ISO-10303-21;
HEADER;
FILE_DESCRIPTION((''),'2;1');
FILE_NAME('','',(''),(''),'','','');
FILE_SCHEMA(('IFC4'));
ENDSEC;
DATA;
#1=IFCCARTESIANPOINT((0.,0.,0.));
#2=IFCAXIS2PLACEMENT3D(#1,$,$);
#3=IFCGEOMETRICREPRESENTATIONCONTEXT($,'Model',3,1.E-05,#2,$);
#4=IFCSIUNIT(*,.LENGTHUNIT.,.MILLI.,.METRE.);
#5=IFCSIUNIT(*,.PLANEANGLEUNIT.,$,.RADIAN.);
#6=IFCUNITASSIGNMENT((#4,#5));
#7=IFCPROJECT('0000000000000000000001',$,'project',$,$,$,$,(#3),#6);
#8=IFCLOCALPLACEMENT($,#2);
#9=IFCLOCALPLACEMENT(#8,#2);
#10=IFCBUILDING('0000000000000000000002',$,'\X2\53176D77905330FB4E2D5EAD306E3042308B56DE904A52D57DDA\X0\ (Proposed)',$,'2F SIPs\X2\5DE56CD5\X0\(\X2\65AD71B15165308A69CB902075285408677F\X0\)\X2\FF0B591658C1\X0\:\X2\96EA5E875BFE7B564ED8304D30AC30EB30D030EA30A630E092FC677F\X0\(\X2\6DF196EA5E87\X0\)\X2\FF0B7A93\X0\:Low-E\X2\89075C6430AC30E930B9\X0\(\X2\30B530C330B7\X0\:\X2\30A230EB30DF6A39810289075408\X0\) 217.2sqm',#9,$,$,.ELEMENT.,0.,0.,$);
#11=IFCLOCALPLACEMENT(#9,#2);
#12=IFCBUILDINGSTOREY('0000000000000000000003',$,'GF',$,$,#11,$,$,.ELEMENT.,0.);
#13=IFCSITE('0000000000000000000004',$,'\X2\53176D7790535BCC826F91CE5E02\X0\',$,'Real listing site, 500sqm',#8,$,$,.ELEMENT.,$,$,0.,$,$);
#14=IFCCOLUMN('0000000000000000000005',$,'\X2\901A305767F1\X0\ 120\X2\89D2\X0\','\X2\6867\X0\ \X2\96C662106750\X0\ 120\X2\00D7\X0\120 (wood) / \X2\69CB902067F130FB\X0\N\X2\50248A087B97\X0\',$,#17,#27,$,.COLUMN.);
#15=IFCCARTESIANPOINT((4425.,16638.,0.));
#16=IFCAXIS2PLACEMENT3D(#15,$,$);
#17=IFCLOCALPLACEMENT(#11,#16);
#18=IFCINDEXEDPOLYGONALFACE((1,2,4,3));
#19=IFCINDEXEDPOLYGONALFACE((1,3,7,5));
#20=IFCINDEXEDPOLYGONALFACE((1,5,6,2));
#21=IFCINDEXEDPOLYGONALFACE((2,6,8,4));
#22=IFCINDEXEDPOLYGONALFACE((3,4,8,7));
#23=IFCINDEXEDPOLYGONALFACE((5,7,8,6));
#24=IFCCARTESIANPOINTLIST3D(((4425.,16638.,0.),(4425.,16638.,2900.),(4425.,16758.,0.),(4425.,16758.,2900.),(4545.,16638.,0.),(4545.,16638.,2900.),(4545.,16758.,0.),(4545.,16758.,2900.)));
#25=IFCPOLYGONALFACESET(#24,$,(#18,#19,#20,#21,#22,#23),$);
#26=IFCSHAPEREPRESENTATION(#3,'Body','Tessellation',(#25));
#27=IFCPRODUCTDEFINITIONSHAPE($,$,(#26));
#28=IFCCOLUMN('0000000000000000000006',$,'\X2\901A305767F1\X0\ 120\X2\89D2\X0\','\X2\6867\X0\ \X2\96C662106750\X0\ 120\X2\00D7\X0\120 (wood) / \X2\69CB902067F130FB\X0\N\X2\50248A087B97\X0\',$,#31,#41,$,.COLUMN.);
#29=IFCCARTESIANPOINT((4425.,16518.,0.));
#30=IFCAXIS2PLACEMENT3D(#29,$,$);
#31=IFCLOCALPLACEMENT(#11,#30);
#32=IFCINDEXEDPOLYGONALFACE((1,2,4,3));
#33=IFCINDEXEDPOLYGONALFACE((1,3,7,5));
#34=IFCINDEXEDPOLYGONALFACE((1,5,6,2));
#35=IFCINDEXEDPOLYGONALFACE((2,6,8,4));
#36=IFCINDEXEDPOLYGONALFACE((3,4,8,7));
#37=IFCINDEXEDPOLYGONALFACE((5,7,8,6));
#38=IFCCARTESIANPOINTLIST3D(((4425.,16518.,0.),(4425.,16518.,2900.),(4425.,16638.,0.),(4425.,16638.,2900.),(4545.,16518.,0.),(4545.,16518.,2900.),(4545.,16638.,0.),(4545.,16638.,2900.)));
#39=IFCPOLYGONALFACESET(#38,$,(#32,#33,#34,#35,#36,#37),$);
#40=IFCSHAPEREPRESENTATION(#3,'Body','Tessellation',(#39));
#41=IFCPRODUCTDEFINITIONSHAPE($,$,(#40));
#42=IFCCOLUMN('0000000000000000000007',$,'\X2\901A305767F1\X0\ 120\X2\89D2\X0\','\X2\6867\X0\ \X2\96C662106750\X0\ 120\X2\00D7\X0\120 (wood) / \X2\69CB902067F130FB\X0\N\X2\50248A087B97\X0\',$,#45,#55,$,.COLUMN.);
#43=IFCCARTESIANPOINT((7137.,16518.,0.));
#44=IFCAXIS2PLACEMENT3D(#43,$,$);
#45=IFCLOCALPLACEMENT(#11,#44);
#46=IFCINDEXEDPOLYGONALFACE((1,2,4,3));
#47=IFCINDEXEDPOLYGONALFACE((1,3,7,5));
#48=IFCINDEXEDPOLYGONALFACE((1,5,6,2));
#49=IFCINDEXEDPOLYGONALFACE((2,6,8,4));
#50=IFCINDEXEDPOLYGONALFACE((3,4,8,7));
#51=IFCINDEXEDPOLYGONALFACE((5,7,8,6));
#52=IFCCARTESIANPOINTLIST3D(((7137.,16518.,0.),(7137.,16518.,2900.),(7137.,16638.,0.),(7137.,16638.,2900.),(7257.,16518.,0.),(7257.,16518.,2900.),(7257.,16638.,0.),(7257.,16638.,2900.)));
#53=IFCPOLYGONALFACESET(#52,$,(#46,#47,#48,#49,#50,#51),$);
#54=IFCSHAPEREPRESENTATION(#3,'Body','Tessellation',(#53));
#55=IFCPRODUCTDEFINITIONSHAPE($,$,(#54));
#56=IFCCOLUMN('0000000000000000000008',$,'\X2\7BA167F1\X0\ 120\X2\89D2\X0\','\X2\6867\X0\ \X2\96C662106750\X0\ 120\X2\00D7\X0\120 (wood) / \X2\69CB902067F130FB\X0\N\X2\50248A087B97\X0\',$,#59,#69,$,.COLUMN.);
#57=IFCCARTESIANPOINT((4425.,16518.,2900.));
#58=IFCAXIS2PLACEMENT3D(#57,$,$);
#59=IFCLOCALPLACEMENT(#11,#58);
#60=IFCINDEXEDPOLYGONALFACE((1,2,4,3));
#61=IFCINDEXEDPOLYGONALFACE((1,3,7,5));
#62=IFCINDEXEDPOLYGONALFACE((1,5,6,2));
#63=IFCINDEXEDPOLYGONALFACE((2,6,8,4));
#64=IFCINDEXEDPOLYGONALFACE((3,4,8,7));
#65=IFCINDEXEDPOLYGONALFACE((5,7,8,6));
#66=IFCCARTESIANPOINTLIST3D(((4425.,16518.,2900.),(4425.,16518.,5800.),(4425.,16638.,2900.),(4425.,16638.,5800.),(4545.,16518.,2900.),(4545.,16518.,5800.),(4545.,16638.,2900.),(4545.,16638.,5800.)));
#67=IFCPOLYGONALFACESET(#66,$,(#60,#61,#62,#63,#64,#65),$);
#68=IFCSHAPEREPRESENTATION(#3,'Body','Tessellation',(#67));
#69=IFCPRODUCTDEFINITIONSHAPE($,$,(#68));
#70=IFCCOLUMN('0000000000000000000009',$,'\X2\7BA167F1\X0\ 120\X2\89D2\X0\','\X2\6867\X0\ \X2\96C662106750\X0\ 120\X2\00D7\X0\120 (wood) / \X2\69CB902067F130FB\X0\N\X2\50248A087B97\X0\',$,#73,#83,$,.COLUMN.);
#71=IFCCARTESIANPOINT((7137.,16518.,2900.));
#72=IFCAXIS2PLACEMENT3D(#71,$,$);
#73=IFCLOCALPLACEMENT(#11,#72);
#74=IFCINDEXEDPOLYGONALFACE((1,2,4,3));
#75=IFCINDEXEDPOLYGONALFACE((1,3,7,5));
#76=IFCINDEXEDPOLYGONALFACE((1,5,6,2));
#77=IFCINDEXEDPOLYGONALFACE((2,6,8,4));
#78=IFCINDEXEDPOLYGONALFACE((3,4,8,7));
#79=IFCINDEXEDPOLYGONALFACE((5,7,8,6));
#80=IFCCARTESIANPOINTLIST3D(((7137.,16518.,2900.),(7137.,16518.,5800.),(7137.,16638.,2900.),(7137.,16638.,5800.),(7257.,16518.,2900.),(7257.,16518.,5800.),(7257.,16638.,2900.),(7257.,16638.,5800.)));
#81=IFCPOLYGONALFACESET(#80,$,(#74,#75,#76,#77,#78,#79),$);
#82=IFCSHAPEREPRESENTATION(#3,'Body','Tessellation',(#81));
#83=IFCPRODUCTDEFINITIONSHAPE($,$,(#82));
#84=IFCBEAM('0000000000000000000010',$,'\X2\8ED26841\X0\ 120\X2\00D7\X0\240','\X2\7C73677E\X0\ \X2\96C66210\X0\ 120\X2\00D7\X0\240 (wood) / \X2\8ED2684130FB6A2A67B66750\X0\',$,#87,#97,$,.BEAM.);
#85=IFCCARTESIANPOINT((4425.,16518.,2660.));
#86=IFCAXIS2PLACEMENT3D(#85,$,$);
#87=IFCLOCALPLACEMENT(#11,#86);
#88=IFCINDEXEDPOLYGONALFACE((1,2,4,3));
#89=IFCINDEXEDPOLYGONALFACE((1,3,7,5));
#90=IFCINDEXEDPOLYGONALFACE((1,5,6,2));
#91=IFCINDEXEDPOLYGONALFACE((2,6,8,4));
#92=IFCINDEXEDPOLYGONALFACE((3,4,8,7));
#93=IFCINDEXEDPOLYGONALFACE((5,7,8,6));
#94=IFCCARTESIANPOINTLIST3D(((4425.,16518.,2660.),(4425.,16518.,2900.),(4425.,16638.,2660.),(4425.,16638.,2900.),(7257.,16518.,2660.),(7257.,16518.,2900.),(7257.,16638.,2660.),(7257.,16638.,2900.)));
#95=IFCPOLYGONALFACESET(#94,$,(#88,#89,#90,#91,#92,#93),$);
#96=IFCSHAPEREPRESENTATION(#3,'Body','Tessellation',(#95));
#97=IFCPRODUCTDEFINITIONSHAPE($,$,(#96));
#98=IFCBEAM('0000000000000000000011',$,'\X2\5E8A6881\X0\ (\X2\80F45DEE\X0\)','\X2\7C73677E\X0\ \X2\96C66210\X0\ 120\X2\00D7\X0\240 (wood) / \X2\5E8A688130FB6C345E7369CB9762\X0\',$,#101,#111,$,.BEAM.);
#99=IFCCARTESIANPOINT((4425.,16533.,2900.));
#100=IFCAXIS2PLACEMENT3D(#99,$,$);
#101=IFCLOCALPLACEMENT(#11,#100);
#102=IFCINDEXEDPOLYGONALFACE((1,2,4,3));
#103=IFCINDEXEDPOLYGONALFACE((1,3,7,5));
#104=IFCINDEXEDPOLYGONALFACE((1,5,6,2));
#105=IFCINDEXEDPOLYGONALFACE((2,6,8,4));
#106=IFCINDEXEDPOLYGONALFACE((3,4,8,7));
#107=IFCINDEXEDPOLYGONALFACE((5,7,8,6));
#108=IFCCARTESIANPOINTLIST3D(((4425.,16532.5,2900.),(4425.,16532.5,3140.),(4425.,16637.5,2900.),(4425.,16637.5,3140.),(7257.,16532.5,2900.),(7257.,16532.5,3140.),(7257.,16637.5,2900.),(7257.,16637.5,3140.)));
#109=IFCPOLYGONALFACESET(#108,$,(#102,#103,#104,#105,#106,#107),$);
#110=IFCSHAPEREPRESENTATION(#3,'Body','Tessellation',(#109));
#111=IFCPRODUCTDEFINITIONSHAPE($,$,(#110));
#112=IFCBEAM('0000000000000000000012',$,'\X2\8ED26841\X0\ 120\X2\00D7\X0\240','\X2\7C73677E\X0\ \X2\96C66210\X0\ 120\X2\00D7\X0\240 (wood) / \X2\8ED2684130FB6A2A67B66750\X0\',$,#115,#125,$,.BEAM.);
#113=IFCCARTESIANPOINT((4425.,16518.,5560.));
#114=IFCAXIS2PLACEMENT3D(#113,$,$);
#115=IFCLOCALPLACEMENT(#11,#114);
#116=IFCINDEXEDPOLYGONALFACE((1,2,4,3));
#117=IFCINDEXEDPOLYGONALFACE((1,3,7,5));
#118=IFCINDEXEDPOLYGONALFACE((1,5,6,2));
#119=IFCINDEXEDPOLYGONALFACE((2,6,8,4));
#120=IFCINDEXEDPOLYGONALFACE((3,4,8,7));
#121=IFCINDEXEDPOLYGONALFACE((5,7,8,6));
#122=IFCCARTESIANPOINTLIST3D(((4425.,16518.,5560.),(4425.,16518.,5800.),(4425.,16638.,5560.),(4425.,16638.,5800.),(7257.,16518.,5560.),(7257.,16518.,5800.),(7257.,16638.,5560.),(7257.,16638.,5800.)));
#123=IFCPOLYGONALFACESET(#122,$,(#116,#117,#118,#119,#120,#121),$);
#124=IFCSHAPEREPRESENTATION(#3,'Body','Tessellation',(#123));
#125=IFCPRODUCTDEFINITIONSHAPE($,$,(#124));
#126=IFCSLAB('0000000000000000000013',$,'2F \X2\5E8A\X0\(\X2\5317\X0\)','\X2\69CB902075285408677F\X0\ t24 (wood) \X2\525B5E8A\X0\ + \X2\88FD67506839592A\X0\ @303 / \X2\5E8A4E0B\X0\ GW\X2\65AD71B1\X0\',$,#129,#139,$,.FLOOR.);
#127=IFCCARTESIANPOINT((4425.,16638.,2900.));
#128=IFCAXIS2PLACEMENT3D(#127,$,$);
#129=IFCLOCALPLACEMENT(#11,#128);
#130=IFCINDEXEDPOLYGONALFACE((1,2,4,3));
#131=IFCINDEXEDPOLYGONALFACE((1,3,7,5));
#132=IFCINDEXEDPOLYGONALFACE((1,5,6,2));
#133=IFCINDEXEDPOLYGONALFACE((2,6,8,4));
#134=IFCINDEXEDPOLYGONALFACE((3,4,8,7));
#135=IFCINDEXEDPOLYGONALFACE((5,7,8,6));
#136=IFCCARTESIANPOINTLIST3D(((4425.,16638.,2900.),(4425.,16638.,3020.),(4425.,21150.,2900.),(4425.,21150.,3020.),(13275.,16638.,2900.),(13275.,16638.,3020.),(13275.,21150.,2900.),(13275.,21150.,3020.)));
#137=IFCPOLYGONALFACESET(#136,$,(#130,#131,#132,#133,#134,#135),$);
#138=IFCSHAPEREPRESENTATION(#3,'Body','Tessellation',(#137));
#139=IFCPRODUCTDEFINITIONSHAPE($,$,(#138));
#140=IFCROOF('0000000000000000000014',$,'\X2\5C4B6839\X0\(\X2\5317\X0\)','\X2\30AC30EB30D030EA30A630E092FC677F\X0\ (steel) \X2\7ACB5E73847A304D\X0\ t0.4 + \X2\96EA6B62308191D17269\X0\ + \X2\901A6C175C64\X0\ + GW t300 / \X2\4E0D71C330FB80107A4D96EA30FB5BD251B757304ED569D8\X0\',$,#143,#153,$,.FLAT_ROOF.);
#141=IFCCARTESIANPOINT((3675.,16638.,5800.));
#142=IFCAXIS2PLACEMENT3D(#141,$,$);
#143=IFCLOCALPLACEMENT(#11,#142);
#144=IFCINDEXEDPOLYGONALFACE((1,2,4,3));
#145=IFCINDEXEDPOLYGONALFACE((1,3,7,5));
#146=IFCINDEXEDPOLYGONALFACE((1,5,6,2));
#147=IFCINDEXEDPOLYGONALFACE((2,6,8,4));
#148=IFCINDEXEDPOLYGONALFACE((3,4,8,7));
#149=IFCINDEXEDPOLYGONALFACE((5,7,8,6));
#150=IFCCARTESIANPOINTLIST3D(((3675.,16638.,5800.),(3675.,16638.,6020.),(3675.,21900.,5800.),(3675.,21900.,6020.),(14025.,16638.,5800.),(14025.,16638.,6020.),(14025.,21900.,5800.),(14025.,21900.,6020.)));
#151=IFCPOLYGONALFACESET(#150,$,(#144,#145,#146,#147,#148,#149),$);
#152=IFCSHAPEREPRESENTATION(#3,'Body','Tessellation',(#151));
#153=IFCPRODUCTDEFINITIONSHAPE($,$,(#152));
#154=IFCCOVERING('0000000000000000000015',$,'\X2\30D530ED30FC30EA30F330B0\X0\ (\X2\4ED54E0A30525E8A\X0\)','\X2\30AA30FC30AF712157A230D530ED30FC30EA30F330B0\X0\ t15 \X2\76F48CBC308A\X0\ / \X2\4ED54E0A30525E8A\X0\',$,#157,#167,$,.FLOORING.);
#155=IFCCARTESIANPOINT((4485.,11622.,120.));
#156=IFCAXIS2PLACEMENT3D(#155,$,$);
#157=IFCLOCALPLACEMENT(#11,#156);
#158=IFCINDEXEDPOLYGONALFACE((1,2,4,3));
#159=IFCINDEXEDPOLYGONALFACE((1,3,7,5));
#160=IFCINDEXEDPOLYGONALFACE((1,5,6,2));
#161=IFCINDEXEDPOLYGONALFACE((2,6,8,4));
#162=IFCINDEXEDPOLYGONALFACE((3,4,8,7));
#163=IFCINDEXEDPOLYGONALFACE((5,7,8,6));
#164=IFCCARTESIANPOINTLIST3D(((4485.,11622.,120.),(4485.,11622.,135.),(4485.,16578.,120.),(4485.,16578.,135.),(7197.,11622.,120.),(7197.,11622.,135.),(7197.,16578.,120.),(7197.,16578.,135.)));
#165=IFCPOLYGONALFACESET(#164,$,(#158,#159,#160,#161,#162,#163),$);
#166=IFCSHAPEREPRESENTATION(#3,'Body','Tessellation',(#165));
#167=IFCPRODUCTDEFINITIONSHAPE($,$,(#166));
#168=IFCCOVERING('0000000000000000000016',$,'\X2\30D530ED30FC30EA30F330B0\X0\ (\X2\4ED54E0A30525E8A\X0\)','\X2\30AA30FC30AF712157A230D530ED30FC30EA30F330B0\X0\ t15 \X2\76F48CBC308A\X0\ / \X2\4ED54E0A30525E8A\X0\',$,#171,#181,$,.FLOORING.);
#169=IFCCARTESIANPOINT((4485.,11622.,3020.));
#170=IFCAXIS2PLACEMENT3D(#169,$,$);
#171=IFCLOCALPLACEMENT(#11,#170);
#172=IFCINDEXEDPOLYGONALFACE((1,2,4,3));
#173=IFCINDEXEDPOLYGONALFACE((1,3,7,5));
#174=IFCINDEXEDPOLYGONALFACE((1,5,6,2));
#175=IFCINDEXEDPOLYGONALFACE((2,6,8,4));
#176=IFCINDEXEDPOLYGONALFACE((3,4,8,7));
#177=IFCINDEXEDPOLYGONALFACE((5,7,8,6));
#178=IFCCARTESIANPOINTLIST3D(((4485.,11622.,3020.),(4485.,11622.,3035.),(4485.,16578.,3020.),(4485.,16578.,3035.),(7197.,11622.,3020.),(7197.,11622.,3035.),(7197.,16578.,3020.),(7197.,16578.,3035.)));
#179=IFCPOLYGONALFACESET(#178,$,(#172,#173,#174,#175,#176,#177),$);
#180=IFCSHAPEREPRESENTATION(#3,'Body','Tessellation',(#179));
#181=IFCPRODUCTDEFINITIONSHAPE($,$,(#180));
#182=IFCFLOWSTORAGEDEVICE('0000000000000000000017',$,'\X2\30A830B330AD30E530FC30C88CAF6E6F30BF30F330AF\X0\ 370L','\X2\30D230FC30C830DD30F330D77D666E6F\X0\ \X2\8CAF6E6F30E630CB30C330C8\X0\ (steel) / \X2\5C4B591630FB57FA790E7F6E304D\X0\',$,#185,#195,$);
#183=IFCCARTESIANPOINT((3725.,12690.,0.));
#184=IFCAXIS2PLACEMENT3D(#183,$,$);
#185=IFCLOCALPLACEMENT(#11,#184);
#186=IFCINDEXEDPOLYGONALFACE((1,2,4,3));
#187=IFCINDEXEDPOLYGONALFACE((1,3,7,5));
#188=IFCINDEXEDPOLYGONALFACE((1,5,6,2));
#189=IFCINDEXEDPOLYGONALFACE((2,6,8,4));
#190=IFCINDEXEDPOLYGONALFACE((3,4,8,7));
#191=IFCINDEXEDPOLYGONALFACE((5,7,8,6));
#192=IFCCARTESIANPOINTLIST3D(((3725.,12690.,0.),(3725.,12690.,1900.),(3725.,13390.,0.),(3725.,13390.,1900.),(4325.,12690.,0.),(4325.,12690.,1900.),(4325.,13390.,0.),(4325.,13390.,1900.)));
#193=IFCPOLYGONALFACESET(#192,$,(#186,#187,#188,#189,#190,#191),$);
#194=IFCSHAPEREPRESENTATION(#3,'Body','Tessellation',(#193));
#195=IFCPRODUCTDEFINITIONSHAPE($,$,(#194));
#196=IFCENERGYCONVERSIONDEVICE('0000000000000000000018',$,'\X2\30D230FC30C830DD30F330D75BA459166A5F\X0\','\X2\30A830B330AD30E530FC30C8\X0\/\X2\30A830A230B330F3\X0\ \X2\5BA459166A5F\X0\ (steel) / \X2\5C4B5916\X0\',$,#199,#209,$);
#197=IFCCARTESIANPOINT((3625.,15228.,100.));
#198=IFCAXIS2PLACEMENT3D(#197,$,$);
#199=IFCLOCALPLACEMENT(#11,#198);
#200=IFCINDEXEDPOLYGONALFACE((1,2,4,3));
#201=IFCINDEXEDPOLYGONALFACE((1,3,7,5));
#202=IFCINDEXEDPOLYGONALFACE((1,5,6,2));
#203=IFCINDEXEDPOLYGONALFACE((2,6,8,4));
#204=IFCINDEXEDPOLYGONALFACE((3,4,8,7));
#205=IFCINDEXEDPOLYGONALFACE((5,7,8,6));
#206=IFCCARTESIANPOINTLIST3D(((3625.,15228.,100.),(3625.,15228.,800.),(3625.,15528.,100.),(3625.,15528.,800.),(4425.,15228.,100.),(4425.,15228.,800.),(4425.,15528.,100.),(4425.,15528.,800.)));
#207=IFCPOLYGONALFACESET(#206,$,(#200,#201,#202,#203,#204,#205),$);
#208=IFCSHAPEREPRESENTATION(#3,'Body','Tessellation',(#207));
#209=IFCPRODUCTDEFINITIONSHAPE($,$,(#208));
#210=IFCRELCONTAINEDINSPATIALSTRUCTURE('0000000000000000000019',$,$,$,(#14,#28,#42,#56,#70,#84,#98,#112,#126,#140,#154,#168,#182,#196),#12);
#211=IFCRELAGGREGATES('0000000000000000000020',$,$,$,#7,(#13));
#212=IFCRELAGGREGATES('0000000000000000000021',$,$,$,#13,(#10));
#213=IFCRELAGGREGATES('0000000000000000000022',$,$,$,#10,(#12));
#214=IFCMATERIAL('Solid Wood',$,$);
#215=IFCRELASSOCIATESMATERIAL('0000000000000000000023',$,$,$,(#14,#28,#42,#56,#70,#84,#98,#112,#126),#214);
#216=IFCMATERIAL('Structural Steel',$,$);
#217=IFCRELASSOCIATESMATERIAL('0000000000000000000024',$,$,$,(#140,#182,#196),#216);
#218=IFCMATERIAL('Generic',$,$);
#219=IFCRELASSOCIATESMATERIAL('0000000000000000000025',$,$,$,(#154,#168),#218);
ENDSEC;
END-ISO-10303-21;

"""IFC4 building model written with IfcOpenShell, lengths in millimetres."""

from ifc_helpers import new_model, si_unit, frame, frame_2d, origin, place, context, project, spatial, rectangle, extrude, material, element, save


model = new_model("IFC4")

# Units and contexts
model_context = context("Model", 3, precision=1e-05, world=origin())
ifc_project = project(units=[si_unit("LENGTHUNIT", "METRE", prefix="MILLI"), si_unit("PLANEANGLEUNIT", "RADIAN")], contexts=[model_context])

# Site, building, storey
site_placement = place(None, origin())
site = spatial("IfcSite", under=ifc_project, at=site_placement, Name="北海道富良野市", ObjectType="Real listing site, 500sqm", CompositionType="ELEMENT", RefElevation=0.0)
building_placement = place(site_placement, origin())
building = spatial("IfcBuilding", under=site, at=building_placement, Name="北海道・中庭のある回遊動線 (Proposed)", ObjectType="2F SIPs工法(断熱入り構造用合板)＋外壁:雪庇対策付きガルバリウム鋼板(深雪庇)＋窓:Low-E複層ガラス(サッシ:アルミ樹脂複合) 217.2sqm", CompositionType="ELEMENT", ElevationOfRefHeight=0.0, ElevationOfTerrain=0.0)
storey_placement = place(building_placement, origin())
storey = spatial("IfcBuildingStorey", under=building, at=storey_placement, Name="GF", CompositionType="ELEMENT", Elevation=0.0)

# Columns
ifc_material_1 = material(Name="Solid Wood")
column_1_placement = place(storey_placement, frame((4425.0, 16638.0, 0.0)))
element("IfcColumn", 1, at=column_1_placement, inside=storey, material=ifc_material_1, Name="通し柱 120角", Description="桧 集成材 120×120 (wood) / 構造柱・N値計算", PredefinedType="COLUMN", context=model_context, shape_type="SweptSolid", body=[
    extrude(rectangle(XDim=120.0, YDim=120.0, at=frame_2d((60.0, 60.0))), frame((4425.0, 16638.0, 0.0)), (0.0, 0.0, 1.0), 2900.0),
])
column_2_placement = place(storey_placement, frame((4425.0, 16518.0, 0.0)))
element("IfcColumn", 2, at=column_2_placement, inside=storey, material=ifc_material_1, Name="通し柱 120角", Description="桧 集成材 120×120 (wood) / 構造柱・N値計算", PredefinedType="COLUMN", context=model_context, shape_type="SweptSolid", body=[
    extrude(rectangle(XDim=120.0, YDim=120.0, at=frame_2d((60.0, 60.0))), frame((4425.0, 16518.0, 0.0)), (0.0, 0.0, 1.0), 2900.0),
])
column_3_placement = place(storey_placement, frame((7137.0, 16518.0, 0.0)))
element("IfcColumn", 3, at=column_3_placement, inside=storey, material=ifc_material_1, Name="通し柱 120角", Description="桧 集成材 120×120 (wood) / 構造柱・N値計算", PredefinedType="COLUMN", context=model_context, shape_type="SweptSolid", body=[
    extrude(rectangle(XDim=120.0, YDim=120.0, at=frame_2d((60.0, 60.0))), frame((7137.0, 16518.0, 0.0)), (0.0, 0.0, 1.0), 2900.0),
])
column_4_placement = place(storey_placement, frame((4425.0, 16518.0, 2900.0)))
element("IfcColumn", 4, at=column_4_placement, inside=storey, material=ifc_material_1, Name="管柱 120角", Description="桧 集成材 120×120 (wood) / 構造柱・N値計算", PredefinedType="COLUMN", context=model_context, shape_type="SweptSolid", body=[
    extrude(rectangle(XDim=120.0, YDim=120.0, at=frame_2d((60.0, 60.0))), frame((4425.0, 16518.0, 2900.0)), (0.0, 0.0, 1.0), 2900.0),
])
column_5_placement = place(storey_placement, frame((7137.0, 16518.0, 2900.0)))
element("IfcColumn", 5, at=column_5_placement, inside=storey, material=ifc_material_1, Name="管柱 120角", Description="桧 集成材 120×120 (wood) / 構造柱・N値計算", PredefinedType="COLUMN", context=model_context, shape_type="SweptSolid", body=[
    extrude(rectangle(XDim=120.0, YDim=120.0, at=frame_2d((60.0, 60.0))), frame((7137.0, 16518.0, 2900.0)), (0.0, 0.0, 1.0), 2900.0),
])

# Beams
beam_1_placement = place(storey_placement, frame((4425.0, 16518.0, 2660.0)))
element("IfcBeam", 6, at=beam_1_placement, inside=storey, material=ifc_material_1, Name="軒桁 120×240", Description="米松 集成 120×240 (wood) / 軒桁・横架材", PredefinedType="BEAM", context=model_context, shape_type="SweptSolid", body=[
    extrude(rectangle(XDim=2832.0, YDim=120.0, at=frame_2d((1416.0, 60.0))), frame((4425.0, 16518.0, 2660.0)), (0.0, 0.0, 1.0), 240.0),
])
beam_2_placement = place(storey_placement, frame((4425.0, 16533.0, 2900.0)))
element("IfcBeam", 7, at=beam_2_placement, inside=storey, material=ifc_material_1, Name="床梁 (胴差)", Description="米松 集成 120×240 (wood) / 床梁・水平構面", PredefinedType="BEAM", context=model_context, shape_type="SweptSolid", body=[
    extrude(rectangle(XDim=2832.0, YDim=105.0, at=frame_2d((1416.0, 52.0))), frame((4425.0, 16533.0, 2900.0)), (0.0, 0.0, 1.0), 240.0),
])
beam_3_placement = place(storey_placement, frame((4425.0, 16518.0, 5560.0)))
element("IfcBeam", 8, at=beam_3_placement, inside=storey, material=ifc_material_1, Name="軒桁 120×240", Description="米松 集成 120×240 (wood) / 軒桁・横架材", PredefinedType="BEAM", context=model_context, shape_type="SweptSolid", body=[
    extrude(rectangle(XDim=2832.0, YDim=120.0, at=frame_2d((1416.0, 60.0))), frame((4425.0, 16518.0, 5560.0)), (0.0, 0.0, 1.0), 240.0),
])

# Slab
slab_1_placement = place(storey_placement, frame((4425.0, 16638.0, 2900.0)))
element("IfcSlab", 9, at=slab_1_placement, inside=storey, material=ifc_material_1, Name="2F 床(北)", Description="構造用合板 t24 (wood) 剛床 + 製材根太 @303 / 床下 GW断熱", PredefinedType="FLOOR", context=model_context, shape_type="SweptSolid", body=[
    extrude(rectangle(XDim=8850.0, YDim=4512.0, at=frame_2d((4425.0, 2256.0))), frame((4425.0, 16638.0, 2900.0)), (0.0, 0.0, 1.0), 120.0),
])

# Roof
ifc_material_2 = material(Name="Structural Steel")
for number, where, name in (
    (10, (3675.0, 16638.0, 5800.0), "屋根(北)"),
):
    element("IfcRoof", number, at=place(storey_placement, frame(where)), inside=storey, material=ifc_material_2, Name=name, Description="ガルバリウム鋼板 (steel) 立平葺き t0.4 + 雪止め金物 + 通気層 + GW t300 / 不燃・耐積雪・寒冷地仕様", PredefinedType="FLAT_ROOF", context=model_context, shape_type="SweptSolid", body=[
        extrude(rectangle(XDim=10350.0, YDim=5262.0, at=frame_2d((5175.0, 2631.0))), frame((3675.0, 16638.0, 5800.0)), (0.0, 0.0, 1.0), 220.0),
    ])

# Coverings
ifc_material_3 = material(Name="Generic")
covering_1_placement = place(storey_placement, frame((4485.0, 11622.0, 120.0)))
element("IfcCovering", 11, at=covering_1_placement, inside=storey, material=ifc_material_3, Name="フローリング (仕上げ床)", Description="オーク無垢フローリング t15 直貼り / 仕上げ床", PredefinedType="FLOORING", context=model_context, shape_type="SweptSolid", body=[
    extrude(rectangle(XDim=2712.0, YDim=4956.0, at=frame_2d((1356.0, 2478.0))), frame((4485.0, 11622.0, 120.0)), (0.0, 0.0, 1.0), 15.0),
])
covering_2_placement = place(storey_placement, frame((4485.0, 11622.0, 3020.0)))
element("IfcCovering", 12, at=covering_2_placement, inside=storey, material=ifc_material_3, Name="フローリング (仕上げ床)", Description="オーク無垢フローリング t15 直貼り / 仕上げ床", PredefinedType="FLOORING", context=model_context, shape_type="SweptSolid", body=[
    extrude(rectangle(XDim=2712.0, YDim=4956.0, at=frame_2d((1356.0, 2478.0))), frame((4485.0, 11622.0, 3020.0)), (0.0, 0.0, 1.0), 15.0),
])

# Flow storage device
flow_storage_device_placement = place(storey_placement, frame((3725.0, 12690.0, 0.0)))
element("IfcFlowStorageDevice", 13, at=flow_storage_device_placement, inside=storey, material=ifc_material_2, Name="エコキュート貯湯タンク 370L", Description="ヒートポンプ給湯 貯湯ユニット (steel) / 屋外・基礎置き", context=model_context, shape_type="SweptSolid", body=[
    extrude(rectangle(XDim=600.0, YDim=700.0, at=frame_2d((300.0, 350.0))), frame((3725.0, 12690.0, 0.0)), (0.0, 0.0, 1.0), 1900.0),
])

# Energy conversion device
energy_conversion_device_placement = place(storey_placement, frame((3625.0, 15228.0, 100.0)))
element("IfcEnergyConversionDevice", 14, at=energy_conversion_device_placement, inside=storey, material=ifc_material_2, Name="ヒートポンプ室外機", Description="エコキュート/エアコン 室外機 (steel) / 屋外", context=model_context, shape_type="SweptSolid", body=[
    extrude(rectangle(XDim=800.0, YDim=300.0, at=frame_2d((400.0, 150.0))), frame((3625.0, 15228.0, 100.0)), (0.0, 0.0, 1.0), 700.0),
])

save(model, "model.ifc")
